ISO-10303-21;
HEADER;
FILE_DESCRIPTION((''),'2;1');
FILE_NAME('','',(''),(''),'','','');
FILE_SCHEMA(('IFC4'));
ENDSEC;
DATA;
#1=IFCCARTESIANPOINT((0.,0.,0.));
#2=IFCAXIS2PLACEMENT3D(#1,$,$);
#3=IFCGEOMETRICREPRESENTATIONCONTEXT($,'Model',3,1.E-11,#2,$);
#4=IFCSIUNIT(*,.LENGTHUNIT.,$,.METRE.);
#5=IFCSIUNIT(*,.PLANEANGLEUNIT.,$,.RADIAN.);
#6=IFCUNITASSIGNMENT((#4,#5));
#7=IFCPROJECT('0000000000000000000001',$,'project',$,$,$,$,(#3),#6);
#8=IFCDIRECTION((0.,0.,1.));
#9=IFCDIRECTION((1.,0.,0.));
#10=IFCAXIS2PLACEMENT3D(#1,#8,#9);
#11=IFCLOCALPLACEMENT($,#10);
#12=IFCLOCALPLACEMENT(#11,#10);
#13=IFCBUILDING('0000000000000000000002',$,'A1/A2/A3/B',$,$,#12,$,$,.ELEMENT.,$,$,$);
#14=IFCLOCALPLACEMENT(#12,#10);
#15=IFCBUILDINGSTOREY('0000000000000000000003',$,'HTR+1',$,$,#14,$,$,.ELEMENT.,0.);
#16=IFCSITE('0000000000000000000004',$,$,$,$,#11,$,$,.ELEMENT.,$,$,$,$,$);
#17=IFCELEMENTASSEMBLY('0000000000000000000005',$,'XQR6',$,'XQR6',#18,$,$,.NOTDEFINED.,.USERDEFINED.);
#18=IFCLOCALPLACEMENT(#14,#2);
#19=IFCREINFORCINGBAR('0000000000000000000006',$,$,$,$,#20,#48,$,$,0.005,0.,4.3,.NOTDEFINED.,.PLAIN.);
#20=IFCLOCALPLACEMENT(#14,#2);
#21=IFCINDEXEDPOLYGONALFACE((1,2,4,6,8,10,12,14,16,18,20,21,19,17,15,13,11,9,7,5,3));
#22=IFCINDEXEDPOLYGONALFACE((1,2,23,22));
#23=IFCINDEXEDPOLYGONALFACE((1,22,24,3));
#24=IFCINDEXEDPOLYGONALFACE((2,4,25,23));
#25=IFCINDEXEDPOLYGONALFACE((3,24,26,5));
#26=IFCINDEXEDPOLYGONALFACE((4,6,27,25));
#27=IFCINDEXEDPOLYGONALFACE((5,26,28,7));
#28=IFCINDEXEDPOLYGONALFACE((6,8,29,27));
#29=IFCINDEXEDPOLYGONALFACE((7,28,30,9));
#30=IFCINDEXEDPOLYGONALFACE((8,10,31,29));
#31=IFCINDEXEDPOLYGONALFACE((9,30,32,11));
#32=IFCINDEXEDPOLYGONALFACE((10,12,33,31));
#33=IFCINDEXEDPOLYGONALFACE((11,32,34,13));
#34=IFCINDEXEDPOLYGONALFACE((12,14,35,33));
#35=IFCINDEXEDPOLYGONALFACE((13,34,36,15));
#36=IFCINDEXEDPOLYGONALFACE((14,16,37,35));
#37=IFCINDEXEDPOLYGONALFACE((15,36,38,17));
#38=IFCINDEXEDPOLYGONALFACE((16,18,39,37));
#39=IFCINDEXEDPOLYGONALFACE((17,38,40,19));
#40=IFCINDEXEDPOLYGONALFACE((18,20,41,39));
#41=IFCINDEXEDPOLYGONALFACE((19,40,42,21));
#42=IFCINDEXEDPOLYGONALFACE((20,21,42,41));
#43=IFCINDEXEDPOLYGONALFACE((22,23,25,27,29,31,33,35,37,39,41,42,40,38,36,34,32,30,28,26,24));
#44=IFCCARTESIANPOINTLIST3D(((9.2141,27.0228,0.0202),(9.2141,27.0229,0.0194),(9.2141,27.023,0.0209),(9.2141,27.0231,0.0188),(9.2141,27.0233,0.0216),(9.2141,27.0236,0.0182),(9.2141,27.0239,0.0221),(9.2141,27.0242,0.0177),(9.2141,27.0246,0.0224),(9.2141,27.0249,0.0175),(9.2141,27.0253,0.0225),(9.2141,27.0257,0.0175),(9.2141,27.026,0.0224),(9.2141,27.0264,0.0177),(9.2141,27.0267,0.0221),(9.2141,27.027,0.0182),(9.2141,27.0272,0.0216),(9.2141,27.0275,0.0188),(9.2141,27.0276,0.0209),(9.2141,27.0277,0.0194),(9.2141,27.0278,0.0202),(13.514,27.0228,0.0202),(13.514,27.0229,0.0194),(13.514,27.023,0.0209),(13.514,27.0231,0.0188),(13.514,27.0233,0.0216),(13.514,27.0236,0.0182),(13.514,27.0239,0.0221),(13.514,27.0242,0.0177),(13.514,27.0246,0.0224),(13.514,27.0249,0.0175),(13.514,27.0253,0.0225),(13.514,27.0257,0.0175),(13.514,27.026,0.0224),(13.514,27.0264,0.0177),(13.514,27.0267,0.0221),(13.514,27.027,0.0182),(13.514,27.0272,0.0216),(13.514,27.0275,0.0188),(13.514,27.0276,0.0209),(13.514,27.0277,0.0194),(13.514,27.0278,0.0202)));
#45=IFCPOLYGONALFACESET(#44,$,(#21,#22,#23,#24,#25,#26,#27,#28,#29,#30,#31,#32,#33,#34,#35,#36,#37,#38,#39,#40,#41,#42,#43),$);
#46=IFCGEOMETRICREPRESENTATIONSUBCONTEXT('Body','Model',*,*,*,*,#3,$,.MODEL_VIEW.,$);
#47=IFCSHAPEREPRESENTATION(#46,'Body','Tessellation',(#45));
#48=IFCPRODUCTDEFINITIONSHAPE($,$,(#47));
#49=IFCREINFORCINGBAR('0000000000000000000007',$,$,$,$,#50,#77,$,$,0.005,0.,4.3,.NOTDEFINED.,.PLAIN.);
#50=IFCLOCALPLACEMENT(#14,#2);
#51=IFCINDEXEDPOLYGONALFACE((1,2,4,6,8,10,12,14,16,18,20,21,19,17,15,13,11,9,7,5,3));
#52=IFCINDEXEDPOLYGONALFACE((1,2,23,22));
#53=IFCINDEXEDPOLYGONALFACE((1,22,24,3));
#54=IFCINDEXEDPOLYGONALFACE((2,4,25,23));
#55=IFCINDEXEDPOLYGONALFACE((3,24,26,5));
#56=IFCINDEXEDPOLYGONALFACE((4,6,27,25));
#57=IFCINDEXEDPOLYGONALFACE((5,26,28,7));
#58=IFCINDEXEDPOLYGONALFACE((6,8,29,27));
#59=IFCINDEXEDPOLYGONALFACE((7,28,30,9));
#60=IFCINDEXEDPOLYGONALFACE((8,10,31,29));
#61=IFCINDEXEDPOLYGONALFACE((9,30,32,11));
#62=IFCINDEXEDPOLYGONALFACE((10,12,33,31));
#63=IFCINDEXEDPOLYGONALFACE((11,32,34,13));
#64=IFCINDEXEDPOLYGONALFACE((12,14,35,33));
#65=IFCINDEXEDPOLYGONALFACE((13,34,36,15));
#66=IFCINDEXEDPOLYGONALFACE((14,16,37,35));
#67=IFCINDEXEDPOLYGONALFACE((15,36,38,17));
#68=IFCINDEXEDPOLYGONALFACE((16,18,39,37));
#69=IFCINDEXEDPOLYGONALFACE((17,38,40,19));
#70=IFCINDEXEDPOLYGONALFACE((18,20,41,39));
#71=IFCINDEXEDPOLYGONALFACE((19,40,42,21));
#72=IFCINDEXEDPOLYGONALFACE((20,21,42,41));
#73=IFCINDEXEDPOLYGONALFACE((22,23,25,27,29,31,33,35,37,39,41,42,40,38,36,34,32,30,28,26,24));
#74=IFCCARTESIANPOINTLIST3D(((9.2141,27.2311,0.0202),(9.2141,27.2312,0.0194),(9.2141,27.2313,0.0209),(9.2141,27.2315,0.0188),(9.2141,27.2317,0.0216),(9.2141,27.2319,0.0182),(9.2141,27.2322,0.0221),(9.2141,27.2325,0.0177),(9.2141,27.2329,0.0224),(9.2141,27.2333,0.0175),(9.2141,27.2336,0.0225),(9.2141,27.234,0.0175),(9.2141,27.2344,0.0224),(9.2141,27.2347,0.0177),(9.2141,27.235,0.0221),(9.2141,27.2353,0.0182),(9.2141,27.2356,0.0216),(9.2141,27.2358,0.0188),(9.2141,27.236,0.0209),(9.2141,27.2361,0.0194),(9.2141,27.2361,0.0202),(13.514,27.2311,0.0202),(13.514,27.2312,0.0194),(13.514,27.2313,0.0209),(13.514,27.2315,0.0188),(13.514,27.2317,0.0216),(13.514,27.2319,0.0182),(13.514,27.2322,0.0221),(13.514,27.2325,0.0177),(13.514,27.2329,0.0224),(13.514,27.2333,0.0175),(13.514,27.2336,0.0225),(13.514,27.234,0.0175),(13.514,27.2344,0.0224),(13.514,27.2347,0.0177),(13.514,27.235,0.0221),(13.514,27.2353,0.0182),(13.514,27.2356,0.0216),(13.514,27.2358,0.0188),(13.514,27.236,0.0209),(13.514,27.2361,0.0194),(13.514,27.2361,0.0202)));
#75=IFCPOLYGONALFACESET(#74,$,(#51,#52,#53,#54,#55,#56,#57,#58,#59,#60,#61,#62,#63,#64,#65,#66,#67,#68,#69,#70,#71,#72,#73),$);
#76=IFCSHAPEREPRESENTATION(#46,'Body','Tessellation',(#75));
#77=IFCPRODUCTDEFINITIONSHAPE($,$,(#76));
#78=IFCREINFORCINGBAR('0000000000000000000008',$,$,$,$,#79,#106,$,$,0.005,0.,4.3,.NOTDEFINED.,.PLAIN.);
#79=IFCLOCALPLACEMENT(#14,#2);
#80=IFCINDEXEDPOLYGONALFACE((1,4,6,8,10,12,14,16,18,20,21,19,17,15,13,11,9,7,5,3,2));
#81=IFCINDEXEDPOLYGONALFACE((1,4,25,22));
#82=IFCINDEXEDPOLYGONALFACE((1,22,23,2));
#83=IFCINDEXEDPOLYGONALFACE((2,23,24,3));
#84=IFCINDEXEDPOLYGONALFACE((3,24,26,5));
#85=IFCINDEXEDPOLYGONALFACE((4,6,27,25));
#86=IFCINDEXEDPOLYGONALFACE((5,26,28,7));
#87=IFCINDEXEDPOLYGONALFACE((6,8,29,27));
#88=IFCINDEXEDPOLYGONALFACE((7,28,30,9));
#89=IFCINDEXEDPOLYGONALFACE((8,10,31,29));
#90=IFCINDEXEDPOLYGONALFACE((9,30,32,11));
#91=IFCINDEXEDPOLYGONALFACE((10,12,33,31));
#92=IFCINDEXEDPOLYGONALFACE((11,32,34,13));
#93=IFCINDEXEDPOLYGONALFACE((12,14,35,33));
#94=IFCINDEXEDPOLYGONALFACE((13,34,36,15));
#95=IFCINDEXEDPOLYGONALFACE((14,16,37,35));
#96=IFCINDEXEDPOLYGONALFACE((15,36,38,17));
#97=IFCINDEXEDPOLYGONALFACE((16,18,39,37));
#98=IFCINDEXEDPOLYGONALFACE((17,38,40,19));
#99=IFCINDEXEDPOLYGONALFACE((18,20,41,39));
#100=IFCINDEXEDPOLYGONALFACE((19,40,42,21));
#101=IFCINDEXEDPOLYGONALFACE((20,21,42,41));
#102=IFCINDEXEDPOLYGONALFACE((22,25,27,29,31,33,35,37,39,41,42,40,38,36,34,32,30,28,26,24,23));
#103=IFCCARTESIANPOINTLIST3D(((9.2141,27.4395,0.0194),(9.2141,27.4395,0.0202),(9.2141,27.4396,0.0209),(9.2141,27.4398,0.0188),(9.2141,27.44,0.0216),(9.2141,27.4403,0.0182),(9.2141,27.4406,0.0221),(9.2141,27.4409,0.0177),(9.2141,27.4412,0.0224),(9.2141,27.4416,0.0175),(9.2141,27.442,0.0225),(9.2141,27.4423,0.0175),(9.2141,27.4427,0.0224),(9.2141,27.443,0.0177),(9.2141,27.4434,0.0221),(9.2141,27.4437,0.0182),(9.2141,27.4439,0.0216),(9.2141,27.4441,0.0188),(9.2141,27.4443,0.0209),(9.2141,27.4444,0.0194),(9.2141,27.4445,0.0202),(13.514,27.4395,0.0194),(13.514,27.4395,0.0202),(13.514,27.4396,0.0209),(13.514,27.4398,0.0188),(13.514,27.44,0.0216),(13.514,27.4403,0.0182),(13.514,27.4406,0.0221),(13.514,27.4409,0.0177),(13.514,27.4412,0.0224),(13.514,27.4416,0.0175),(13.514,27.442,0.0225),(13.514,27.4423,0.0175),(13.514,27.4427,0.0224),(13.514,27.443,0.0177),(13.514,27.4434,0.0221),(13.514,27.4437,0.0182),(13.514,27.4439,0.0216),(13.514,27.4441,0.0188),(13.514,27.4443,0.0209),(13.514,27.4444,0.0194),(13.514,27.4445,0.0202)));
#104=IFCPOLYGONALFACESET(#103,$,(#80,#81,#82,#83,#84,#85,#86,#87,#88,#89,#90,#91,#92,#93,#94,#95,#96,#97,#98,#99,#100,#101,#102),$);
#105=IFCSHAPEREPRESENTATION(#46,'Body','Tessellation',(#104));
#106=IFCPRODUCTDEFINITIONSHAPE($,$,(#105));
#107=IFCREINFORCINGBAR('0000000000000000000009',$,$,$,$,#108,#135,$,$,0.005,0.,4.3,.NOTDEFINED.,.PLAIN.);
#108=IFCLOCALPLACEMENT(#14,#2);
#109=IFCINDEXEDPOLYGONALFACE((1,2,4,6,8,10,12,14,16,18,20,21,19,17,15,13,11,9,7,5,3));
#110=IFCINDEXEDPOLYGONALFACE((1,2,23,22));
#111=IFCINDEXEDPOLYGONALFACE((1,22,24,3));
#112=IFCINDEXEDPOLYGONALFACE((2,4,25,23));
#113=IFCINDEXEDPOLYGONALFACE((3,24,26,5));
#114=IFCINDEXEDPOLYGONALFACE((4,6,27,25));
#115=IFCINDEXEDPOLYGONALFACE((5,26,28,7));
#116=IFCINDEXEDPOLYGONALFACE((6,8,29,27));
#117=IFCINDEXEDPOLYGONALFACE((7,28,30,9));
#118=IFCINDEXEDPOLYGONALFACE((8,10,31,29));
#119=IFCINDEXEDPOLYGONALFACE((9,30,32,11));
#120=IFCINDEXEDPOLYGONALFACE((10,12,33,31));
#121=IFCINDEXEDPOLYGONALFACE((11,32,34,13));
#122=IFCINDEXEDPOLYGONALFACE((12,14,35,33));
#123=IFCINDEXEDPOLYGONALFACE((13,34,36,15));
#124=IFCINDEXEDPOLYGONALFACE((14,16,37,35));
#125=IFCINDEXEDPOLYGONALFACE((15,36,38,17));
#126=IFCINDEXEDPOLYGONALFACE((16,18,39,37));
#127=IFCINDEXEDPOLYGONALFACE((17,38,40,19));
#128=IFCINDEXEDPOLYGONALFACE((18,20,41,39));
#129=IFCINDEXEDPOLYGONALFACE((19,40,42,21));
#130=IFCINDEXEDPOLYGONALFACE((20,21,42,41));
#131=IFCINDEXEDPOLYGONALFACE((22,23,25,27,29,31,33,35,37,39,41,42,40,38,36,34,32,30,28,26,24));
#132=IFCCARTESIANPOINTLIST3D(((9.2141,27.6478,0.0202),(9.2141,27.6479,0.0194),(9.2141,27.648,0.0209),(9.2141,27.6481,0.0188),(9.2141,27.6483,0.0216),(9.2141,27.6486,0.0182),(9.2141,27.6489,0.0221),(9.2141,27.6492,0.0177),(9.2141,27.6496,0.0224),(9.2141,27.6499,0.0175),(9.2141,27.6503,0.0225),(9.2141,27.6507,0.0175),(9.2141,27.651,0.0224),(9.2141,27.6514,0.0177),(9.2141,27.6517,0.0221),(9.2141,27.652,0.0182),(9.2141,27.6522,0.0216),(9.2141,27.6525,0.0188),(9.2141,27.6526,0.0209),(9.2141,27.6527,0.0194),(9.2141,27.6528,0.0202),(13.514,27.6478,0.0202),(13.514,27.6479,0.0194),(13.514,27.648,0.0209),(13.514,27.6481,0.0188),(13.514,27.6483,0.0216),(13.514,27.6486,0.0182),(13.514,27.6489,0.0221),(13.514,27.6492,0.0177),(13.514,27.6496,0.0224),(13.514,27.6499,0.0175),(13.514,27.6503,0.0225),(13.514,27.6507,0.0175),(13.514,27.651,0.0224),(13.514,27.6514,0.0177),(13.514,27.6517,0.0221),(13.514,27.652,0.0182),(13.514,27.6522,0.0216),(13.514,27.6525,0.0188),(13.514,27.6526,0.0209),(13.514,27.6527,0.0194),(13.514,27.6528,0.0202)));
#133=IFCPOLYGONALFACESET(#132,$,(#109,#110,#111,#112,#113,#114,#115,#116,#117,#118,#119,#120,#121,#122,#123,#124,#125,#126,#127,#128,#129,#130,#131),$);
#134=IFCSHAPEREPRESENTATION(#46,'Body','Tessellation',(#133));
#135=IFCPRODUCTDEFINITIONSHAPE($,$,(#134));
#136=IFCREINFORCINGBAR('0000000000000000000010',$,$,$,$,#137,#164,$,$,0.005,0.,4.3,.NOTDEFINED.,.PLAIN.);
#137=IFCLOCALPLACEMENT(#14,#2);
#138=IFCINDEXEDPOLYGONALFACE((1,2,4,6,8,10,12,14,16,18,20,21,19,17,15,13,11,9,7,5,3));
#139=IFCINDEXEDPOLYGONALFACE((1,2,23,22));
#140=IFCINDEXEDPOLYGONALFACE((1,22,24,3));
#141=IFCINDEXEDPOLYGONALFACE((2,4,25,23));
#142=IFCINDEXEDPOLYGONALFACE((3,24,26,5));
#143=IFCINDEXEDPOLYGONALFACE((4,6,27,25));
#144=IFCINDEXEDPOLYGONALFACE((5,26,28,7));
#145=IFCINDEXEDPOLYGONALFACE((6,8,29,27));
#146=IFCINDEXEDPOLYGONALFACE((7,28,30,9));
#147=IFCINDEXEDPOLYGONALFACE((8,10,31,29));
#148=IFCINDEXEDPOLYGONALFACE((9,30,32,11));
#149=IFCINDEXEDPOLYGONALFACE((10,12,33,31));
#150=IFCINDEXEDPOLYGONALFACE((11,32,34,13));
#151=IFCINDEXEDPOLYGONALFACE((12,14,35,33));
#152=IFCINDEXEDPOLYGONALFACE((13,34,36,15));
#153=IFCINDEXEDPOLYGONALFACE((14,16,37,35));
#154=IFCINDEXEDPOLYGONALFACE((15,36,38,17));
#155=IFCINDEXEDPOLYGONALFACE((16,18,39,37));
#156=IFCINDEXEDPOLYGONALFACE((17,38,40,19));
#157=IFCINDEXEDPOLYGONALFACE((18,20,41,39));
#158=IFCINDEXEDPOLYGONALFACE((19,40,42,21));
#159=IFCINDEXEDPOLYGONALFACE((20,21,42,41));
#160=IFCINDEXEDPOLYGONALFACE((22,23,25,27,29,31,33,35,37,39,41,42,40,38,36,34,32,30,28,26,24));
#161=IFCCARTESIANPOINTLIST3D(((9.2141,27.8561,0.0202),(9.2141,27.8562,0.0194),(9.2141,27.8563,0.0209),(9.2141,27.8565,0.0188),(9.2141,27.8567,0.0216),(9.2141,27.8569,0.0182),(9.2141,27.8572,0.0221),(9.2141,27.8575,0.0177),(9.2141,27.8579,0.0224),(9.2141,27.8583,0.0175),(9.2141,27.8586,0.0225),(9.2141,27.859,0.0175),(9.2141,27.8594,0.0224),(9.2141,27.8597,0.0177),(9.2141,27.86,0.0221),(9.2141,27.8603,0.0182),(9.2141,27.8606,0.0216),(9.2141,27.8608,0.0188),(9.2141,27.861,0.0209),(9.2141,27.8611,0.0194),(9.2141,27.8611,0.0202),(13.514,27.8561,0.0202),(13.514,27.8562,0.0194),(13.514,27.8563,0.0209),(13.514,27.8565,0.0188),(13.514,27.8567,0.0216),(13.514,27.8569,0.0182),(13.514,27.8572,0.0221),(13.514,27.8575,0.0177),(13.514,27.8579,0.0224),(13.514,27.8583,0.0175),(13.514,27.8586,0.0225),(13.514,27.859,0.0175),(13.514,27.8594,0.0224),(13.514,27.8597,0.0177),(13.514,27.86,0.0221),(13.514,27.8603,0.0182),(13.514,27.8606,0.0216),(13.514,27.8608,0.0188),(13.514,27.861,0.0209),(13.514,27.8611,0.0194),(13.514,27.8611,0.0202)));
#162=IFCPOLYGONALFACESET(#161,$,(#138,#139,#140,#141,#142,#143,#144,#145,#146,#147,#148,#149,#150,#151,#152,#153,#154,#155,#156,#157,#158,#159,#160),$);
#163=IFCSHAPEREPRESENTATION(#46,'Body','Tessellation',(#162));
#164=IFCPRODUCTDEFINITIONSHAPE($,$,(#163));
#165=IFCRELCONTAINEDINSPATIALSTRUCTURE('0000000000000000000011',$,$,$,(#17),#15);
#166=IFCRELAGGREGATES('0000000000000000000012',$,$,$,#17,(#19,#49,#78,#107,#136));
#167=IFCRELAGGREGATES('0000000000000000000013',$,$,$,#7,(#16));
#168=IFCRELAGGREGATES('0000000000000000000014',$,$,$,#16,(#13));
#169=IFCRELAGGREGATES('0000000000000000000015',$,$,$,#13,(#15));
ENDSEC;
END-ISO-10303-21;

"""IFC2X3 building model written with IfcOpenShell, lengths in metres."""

from ifc_helpers import new_model, entity, si_unit, origin, origin_with_axes, place, context, subcontext, project, spatial, shape, element, aggregate, save


model = new_model("IFC2X3")

# Units and contexts
model_context = context("Model", 3, precision=1e-11, world=origin())
body_context = subcontext(model_context, "Body", "Model", "MODEL_VIEW")
ifc_project = project(units=[si_unit("LENGTHUNIT", "METRE"), si_unit("PLANEANGLEUNIT", "RADIAN")], contexts=[model_context])

# Site, building, storey
site_placement = place(None, origin_with_axes())
site = spatial("IfcSite", under=ifc_project, at=site_placement, CompositionType="ELEMENT")
building_placement = place(site_placement, origin_with_axes())
building = spatial("IfcBuilding", under=site, at=building_placement, Name="A1/A2/A3/B", CompositionType="ELEMENT")
storey_placement = place(building_placement, origin_with_axes())
storey = spatial("IfcBuildingStorey", under=building, at=storey_placement, Name="HTR+1", CompositionType="ELEMENT", Elevation=0.0)

# Element assembly, reinforcing bars
assembly_1_placement = place(storey_placement, origin_with_axes())
assembly_1 = element("IfcElementAssembly", 1, at=assembly_1_placement, inside=storey, Name="XQR6", ObjectType="XQR6", AssemblyPlace="NOTDEFINED", PredefinedType="USERDEFINED")
reinforcing_bar_1_placement = place(assembly_1_placement, origin_with_axes())
reinforcing_bar_1 = element("IfcReinforcingBar", 2, at=reinforcing_bar_1_placement, BarLength=4.3, BarRole="NOTDEFINED", BarSurface="PLAIN", CrossSectionArea=0.0, NominalDiameter=0.005, shapes=[
    shape(body_context, "Body", "AdvancedSweptSolid", [entity("IfcSweptDiskSolid", entity("IfcPolyline", [entity("IfcCartesianPoint", [9.2141, 27.0253, 0.02]), entity("IfcCartesianPoint", [13.514, 27.0253, 0.02])]), 0.0025, None, 0.0, 4.3)]),
    shape(body_context, "Body", "AdvancedSweptSolid", [entity("IfcSweptDiskSolid", entity("IfcPolyline", [entity("IfcCartesianPoint", [9.2141, 27.0253, 0.02]), entity("IfcCartesianPoint", [13.514, 27.0253, 0.02])]), 0.0025, None, 0.0, 4.3)]),
])
reinforcing_bar_2_placement = place(assembly_1_placement, origin_with_axes())
reinforcing_bar_2 = element("IfcReinforcingBar", 3, at=reinforcing_bar_2_placement, BarLength=4.3, BarRole="NOTDEFINED", BarSurface="PLAIN", CrossSectionArea=0.0, NominalDiameter=0.005, shapes=[
    shape(body_context, "Body", "AdvancedSweptSolid", [entity("IfcSweptDiskSolid", entity("IfcPolyline", [entity("IfcCartesianPoint", [9.2141, 27.2336, 0.02]), entity("IfcCartesianPoint", [13.514, 27.2336, 0.02])]), 0.0025, None, 0.0, 4.3)]),
    shape(body_context, "Body", "AdvancedSweptSolid", [entity("IfcSweptDiskSolid", entity("IfcPolyline", [entity("IfcCartesianPoint", [9.2141, 27.2336, 0.02]), entity("IfcCartesianPoint", [13.514, 27.2336, 0.02])]), 0.0025, None, 0.0, 4.3)]),
])
reinforcing_bar_3_placement = place(assembly_1_placement, origin_with_axes())
reinforcing_bar_3 = element("IfcReinforcingBar", 4, at=reinforcing_bar_3_placement, BarLength=4.3, BarRole="NOTDEFINED", BarSurface="PLAIN", CrossSectionArea=0.0, NominalDiameter=0.005, shapes=[
    shape(body_context, "Body", "AdvancedSweptSolid", [entity("IfcSweptDiskSolid", entity("IfcPolyline", [entity("IfcCartesianPoint", [9.2141, 27.442, 0.02]), entity("IfcCartesianPoint", [13.514, 27.442, 0.02])]), 0.0025, None, 0.0, 4.3)]),
    shape(body_context, "Body", "AdvancedSweptSolid", [entity("IfcSweptDiskSolid", entity("IfcPolyline", [entity("IfcCartesianPoint", [9.2141, 27.442, 0.02]), entity("IfcCartesianPoint", [13.514, 27.442, 0.02])]), 0.0025, None, 0.0, 4.3)]),
])
reinforcing_bar_4_placement = place(assembly_1_placement, origin_with_axes())
reinforcing_bar_4 = element("IfcReinforcingBar", 5, at=reinforcing_bar_4_placement, BarLength=4.3, BarRole="NOTDEFINED", BarSurface="PLAIN", CrossSectionArea=0.0, NominalDiameter=0.005, shapes=[
    shape(body_context, "Body", "AdvancedSweptSolid", [entity("IfcSweptDiskSolid", entity("IfcPolyline", [entity("IfcCartesianPoint", [9.2141, 27.6503, 0.02]), entity("IfcCartesianPoint", [13.514, 27.6503, 0.02])]), 0.0025, None, 0.0, 4.3)]),
    shape(body_context, "Body", "AdvancedSweptSolid", [entity("IfcSweptDiskSolid", entity("IfcPolyline", [entity("IfcCartesianPoint", [9.2141, 27.6503, 0.02]), entity("IfcCartesianPoint", [13.514, 27.6503, 0.02])]), 0.0025, None, 0.0, 4.3)]),
])
reinforcing_bar_5_placement = place(assembly_1_placement, origin_with_axes())
reinforcing_bar_5 = element("IfcReinforcingBar", 6, at=reinforcing_bar_5_placement, BarLength=4.3, BarRole="NOTDEFINED", BarSurface="PLAIN", CrossSectionArea=0.0, NominalDiameter=0.005, shapes=[
    shape(body_context, "Body", "AdvancedSweptSolid", [entity("IfcSweptDiskSolid", entity("IfcPolyline", [entity("IfcCartesianPoint", [9.2141, 27.8586, 0.02]), entity("IfcCartesianPoint", [13.514, 27.8586, 0.02])]), 0.0025, None, 0.0, 4.3)]),
    shape(body_context, "Body", "AdvancedSweptSolid", [entity("IfcSweptDiskSolid", entity("IfcPolyline", [entity("IfcCartesianPoint", [9.2141, 27.8586, 0.02]), entity("IfcCartesianPoint", [13.514, 27.8586, 0.02])]), 0.0025, None, 0.0, 4.3)]),
])
aggregate(assembly_1, [reinforcing_bar_1, reinforcing_bar_2, reinforcing_bar_3, reinforcing_bar_4, reinforcing_bar_5])

save(model, "model.ifc")
